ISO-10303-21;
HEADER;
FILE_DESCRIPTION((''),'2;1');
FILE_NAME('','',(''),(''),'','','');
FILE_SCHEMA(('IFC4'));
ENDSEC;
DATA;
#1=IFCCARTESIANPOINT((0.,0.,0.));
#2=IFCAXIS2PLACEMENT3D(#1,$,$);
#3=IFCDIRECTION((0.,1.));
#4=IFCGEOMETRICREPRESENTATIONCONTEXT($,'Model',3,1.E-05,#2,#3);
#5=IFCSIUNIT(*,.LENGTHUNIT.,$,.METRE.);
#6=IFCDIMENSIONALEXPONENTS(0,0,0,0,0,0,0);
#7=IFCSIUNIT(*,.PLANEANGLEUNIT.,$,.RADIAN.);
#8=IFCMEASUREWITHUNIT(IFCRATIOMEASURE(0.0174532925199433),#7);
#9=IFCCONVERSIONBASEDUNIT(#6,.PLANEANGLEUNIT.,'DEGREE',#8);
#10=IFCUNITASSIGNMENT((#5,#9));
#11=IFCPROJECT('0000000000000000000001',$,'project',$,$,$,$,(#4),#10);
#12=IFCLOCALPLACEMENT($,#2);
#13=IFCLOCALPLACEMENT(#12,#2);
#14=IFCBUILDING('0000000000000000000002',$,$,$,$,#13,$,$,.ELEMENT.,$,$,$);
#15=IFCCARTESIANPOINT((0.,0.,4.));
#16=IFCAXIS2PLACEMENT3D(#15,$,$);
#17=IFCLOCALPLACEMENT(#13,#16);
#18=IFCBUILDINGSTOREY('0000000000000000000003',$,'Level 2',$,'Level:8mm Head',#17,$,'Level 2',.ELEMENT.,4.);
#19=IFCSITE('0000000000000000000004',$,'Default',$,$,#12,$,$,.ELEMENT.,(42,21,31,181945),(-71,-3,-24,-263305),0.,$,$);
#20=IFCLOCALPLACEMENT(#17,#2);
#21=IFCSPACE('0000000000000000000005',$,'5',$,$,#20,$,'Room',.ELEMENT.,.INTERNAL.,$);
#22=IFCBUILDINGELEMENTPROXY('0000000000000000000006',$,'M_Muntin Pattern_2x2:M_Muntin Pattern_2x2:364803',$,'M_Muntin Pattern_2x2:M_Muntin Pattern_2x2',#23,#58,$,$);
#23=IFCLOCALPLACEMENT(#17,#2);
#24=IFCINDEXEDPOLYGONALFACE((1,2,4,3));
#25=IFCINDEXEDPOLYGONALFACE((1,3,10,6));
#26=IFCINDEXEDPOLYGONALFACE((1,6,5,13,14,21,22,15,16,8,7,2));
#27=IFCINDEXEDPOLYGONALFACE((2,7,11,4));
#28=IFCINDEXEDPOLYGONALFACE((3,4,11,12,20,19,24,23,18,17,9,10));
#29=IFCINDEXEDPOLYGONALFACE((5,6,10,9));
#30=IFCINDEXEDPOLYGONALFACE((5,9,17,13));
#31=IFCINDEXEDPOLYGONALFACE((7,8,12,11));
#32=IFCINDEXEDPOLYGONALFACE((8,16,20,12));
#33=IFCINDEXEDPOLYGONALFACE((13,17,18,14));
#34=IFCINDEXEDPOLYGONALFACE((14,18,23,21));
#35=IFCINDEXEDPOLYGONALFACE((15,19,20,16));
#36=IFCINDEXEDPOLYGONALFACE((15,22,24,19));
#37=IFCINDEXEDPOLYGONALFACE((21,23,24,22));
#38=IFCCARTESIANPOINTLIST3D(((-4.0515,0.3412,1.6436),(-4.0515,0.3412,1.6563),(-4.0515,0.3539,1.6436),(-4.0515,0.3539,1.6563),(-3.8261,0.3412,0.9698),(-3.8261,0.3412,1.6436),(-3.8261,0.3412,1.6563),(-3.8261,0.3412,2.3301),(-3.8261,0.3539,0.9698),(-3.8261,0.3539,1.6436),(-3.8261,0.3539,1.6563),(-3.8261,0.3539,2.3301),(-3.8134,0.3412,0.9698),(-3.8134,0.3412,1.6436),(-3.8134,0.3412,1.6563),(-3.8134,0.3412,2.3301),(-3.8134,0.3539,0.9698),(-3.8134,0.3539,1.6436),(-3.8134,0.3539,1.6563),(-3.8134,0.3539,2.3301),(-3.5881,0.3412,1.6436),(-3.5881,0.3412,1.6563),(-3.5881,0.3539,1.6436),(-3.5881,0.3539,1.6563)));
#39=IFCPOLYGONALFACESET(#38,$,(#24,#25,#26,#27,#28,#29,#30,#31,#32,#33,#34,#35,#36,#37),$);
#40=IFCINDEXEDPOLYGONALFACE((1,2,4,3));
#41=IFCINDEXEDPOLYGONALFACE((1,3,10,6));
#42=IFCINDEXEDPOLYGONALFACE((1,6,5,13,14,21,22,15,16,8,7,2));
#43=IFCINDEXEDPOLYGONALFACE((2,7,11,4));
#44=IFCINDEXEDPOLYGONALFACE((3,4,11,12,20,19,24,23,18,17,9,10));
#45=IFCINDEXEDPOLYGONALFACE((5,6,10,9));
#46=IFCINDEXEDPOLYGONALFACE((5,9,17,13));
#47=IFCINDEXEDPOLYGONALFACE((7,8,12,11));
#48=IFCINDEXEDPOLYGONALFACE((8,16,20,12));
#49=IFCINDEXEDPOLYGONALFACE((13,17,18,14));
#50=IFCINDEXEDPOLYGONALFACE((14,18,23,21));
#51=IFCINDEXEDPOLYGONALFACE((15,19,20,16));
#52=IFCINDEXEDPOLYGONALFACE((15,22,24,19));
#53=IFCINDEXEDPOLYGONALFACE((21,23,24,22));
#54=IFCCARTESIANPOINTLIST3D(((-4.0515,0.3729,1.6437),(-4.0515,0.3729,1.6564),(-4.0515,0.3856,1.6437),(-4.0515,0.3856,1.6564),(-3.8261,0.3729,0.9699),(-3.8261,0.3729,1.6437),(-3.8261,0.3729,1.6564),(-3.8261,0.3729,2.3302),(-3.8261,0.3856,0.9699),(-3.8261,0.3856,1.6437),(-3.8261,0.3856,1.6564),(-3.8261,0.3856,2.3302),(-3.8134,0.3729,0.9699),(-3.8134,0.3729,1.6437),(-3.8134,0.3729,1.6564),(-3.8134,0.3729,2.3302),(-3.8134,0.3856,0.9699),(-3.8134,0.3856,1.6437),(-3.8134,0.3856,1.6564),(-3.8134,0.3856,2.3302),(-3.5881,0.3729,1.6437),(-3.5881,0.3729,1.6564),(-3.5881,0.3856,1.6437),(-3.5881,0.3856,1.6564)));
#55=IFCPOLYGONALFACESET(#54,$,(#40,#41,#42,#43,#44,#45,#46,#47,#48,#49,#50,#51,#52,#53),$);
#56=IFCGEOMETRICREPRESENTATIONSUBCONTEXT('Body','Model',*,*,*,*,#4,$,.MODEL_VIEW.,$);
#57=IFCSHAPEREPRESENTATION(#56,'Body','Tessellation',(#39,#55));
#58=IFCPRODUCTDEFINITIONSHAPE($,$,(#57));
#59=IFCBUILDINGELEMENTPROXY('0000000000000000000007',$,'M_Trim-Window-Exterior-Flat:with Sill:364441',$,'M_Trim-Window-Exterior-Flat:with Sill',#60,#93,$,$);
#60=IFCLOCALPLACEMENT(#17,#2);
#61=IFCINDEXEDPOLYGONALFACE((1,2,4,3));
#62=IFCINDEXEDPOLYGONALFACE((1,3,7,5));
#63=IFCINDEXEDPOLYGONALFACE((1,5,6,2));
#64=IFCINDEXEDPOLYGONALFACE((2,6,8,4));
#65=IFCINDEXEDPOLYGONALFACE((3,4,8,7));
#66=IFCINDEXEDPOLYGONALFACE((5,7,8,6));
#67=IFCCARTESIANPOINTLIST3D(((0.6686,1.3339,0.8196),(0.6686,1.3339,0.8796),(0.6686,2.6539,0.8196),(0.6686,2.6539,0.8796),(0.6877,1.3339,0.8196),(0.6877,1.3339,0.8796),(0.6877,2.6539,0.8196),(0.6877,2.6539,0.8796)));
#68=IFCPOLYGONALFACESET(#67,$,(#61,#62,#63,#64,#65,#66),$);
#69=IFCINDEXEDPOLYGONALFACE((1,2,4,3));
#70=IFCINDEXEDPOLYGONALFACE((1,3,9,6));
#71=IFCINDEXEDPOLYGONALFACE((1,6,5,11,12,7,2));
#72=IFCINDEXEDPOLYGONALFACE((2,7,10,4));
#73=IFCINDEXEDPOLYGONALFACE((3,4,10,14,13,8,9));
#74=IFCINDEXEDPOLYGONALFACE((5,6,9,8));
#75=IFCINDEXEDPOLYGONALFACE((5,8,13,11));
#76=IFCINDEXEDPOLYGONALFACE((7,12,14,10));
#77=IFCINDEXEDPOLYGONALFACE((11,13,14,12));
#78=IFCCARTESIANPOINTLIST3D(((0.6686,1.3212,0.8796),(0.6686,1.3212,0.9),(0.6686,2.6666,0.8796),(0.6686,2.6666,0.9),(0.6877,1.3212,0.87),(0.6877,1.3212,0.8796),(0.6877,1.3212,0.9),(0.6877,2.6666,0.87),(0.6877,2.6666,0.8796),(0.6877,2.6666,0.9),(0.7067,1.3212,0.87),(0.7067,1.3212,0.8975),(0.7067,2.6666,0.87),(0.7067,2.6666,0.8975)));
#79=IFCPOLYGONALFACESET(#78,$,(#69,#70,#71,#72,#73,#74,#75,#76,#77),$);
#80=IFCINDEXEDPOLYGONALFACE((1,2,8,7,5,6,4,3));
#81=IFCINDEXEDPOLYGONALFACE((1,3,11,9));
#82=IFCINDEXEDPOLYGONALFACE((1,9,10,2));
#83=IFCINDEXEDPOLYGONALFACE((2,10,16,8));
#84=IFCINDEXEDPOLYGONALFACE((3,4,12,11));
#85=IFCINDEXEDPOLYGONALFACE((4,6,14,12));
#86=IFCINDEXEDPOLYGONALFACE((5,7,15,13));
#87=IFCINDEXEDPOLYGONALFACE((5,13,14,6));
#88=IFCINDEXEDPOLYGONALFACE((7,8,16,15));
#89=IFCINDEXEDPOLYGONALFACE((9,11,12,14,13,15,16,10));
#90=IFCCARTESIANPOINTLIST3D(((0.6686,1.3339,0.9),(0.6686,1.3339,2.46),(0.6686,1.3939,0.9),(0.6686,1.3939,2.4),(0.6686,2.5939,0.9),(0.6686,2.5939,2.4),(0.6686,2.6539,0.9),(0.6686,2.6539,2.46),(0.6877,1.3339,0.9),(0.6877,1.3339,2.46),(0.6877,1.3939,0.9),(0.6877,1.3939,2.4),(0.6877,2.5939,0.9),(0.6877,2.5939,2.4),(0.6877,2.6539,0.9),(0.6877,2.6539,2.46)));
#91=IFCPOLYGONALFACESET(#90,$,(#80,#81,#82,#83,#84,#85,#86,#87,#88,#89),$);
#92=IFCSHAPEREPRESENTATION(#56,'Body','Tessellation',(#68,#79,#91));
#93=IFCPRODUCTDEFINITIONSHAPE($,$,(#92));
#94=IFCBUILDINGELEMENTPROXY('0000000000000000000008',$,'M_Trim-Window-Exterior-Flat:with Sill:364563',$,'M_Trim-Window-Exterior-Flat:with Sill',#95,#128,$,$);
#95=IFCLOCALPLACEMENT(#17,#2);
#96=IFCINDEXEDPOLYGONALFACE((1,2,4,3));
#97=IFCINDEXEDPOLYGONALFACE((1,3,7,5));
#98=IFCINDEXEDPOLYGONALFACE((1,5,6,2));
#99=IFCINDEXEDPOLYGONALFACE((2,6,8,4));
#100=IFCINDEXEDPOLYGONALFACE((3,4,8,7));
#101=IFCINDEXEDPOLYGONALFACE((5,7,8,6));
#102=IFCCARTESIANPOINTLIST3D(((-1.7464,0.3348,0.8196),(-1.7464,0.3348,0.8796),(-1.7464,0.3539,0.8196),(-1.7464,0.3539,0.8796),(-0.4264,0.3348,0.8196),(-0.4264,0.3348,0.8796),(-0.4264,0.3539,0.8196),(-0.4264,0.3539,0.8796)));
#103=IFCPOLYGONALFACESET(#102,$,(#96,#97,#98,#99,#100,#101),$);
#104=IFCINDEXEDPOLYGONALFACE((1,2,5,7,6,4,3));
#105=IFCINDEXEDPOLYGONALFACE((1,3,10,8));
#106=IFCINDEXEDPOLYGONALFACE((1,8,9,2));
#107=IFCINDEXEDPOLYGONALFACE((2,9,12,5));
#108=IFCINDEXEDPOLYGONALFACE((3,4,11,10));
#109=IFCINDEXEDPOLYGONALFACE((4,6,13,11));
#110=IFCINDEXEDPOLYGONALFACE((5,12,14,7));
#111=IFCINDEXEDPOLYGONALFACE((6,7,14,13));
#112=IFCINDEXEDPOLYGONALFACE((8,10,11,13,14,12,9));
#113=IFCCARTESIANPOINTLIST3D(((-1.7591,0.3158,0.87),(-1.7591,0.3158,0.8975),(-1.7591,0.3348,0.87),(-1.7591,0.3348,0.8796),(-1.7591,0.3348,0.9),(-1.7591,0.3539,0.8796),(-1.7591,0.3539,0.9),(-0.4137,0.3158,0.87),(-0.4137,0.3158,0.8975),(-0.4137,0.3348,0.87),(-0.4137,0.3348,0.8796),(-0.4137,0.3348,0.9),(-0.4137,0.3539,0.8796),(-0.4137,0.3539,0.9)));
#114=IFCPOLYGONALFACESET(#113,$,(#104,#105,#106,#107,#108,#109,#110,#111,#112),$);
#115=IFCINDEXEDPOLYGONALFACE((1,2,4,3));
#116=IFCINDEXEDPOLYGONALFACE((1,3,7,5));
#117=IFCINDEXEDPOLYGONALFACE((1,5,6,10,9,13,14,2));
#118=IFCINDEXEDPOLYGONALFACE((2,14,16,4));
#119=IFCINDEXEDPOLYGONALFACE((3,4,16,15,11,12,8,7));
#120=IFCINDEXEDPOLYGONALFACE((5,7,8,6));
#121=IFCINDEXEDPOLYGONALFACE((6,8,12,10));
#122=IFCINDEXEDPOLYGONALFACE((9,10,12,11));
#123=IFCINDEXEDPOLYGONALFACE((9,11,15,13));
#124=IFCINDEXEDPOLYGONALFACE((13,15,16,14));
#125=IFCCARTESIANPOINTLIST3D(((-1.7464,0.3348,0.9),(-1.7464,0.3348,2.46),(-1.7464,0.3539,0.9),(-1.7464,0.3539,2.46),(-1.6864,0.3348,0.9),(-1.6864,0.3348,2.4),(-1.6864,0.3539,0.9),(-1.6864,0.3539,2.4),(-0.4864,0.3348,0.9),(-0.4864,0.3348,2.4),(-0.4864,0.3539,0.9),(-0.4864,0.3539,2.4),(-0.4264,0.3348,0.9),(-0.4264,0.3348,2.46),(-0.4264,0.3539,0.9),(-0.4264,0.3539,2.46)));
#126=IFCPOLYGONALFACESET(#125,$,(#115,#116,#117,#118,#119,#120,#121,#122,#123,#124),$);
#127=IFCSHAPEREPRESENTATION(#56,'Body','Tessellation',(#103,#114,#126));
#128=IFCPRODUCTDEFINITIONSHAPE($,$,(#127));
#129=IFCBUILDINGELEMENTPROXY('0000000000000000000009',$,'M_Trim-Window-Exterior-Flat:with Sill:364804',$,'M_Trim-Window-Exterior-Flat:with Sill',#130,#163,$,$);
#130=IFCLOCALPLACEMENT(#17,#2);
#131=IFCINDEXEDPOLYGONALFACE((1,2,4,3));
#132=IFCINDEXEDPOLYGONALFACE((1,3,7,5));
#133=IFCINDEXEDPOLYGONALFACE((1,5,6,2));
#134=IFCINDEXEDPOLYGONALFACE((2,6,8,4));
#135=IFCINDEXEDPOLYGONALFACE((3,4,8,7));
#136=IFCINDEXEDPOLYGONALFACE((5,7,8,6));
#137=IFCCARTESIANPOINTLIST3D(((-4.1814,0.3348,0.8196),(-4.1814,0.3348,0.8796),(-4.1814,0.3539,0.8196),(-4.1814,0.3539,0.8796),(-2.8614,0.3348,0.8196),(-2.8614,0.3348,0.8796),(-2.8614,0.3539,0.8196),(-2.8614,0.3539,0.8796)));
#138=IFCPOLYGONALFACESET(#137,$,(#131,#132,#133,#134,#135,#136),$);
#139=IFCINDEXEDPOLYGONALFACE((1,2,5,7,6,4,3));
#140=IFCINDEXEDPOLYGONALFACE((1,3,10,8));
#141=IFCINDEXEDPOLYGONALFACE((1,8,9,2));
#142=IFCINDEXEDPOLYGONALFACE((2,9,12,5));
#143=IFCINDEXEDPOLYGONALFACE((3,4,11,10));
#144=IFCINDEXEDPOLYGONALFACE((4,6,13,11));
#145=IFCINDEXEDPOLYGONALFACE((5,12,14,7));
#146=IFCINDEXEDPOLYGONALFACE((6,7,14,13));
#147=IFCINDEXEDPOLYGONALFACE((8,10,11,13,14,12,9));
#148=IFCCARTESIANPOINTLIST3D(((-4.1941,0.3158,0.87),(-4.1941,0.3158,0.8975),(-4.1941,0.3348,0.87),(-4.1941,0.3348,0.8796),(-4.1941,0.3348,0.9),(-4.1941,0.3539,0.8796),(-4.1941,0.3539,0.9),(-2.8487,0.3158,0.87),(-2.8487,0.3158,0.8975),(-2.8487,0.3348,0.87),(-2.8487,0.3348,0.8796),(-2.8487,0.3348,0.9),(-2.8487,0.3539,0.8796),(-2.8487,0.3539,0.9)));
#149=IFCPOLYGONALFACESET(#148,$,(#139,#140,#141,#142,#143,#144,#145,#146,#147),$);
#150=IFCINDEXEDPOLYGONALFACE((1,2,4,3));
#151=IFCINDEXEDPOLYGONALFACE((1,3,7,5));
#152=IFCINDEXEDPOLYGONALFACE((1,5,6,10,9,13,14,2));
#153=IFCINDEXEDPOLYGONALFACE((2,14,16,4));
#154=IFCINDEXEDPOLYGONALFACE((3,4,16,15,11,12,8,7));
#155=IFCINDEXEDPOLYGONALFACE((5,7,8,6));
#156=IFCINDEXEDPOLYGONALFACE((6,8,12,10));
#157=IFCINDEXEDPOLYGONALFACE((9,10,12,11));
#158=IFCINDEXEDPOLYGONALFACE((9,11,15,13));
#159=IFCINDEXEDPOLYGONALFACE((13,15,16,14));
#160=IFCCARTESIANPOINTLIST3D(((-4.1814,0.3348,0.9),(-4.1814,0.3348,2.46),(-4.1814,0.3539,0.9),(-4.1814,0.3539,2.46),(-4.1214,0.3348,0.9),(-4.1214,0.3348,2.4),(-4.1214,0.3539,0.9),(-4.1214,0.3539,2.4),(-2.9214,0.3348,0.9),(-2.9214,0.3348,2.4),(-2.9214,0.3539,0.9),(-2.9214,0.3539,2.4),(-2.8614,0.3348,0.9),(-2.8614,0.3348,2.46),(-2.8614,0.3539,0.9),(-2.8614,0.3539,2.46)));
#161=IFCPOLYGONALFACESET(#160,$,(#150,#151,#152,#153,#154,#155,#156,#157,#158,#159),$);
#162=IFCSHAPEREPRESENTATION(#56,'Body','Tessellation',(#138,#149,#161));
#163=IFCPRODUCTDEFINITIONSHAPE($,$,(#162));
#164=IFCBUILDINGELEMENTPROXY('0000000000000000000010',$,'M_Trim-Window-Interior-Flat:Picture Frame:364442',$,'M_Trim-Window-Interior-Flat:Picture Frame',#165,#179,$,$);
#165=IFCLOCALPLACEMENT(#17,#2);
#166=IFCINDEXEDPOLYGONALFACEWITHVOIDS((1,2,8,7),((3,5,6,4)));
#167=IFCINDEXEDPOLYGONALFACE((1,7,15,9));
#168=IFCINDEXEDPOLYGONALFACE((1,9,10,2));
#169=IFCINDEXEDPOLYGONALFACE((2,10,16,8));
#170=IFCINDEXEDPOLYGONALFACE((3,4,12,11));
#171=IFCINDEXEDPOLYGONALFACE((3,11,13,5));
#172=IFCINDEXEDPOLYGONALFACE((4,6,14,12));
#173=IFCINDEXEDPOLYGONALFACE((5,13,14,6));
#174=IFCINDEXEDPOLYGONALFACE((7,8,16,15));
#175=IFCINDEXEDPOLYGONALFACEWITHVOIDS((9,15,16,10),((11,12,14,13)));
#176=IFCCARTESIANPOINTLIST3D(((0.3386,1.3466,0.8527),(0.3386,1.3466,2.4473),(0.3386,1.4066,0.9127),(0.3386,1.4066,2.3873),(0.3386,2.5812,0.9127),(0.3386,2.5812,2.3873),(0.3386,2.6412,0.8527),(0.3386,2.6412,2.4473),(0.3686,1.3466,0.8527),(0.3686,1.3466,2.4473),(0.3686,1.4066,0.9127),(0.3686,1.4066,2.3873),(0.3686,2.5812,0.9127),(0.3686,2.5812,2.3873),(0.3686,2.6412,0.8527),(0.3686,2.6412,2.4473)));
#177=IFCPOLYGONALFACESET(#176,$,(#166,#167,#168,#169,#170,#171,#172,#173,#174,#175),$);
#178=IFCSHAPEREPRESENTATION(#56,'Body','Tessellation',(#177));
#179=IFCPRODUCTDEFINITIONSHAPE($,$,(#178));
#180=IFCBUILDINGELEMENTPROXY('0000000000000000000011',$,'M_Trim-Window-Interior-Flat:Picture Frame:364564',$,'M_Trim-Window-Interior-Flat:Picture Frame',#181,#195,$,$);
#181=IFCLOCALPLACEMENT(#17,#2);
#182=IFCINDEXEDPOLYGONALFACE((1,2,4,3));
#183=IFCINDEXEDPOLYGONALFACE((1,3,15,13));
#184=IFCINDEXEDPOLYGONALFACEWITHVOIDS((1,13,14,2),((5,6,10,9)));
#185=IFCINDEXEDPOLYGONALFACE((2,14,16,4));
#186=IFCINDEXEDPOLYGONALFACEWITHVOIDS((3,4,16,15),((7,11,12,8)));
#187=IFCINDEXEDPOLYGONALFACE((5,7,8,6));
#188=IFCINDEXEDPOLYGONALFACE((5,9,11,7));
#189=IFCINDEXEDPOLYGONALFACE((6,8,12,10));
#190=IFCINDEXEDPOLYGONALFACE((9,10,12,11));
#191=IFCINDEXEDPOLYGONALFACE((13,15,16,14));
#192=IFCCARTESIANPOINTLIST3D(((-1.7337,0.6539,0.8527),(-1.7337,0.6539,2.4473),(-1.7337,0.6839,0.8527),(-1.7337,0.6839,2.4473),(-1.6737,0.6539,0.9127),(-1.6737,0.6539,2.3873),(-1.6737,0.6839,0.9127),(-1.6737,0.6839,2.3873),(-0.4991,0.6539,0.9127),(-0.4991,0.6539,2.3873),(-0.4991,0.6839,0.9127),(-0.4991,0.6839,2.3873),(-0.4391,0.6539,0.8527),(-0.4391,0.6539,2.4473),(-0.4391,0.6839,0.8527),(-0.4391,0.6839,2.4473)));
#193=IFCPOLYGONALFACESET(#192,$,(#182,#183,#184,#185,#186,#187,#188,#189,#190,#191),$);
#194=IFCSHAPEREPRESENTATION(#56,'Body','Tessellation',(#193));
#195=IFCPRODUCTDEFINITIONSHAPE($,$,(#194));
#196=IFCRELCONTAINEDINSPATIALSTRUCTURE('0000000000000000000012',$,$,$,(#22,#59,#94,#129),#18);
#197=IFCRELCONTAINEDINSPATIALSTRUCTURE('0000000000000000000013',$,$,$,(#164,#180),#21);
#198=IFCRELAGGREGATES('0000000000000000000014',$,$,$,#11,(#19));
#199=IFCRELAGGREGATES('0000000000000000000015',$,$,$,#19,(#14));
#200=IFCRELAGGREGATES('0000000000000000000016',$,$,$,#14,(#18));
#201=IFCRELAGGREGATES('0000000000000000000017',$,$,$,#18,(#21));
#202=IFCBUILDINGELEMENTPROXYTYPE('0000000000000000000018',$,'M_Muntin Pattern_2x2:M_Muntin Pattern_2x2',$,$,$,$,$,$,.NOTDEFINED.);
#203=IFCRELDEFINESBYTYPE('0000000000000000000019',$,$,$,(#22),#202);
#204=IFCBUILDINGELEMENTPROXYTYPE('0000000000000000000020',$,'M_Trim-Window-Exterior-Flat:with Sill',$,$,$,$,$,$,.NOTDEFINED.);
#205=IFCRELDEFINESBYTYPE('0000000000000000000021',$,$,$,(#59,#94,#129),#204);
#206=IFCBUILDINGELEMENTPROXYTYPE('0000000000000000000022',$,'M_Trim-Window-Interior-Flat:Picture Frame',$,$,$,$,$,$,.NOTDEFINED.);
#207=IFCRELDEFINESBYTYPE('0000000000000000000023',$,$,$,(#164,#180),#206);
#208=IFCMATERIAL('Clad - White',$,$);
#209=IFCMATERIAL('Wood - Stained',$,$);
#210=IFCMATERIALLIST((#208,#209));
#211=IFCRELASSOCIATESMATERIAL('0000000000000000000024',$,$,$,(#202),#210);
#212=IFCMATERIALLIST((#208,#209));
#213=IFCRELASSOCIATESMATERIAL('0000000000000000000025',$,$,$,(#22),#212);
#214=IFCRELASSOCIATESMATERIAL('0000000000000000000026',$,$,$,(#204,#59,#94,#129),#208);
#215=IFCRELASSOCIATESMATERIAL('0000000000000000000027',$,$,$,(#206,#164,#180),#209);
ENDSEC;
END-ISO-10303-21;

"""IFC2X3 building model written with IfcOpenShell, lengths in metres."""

from ifc_helpers import new_model, entity, si_unit, converted_unit, direction, frame, frame_2d, origin, place, context, subcontext, project, spatial, polyline, rectangle, outline, extrude, source, transform, mapped, material, material_list, type_object, type_shapes, element, save


model = new_model("IFC2X3")

# Units and contexts
model_context = context("Model", 3, precision=1e-05, world=origin(), true_north=direction((0.0, 1.0)))
body_context = subcontext(model_context, "Body", "Model", "MODEL_VIEW")
ifc_project = project(units=[si_unit("LENGTHUNIT", "METRE"), converted_unit("PLANEANGLEUNIT", "DEGREE", entity("IfcRatioMeasure", 0.0174532925199433), si_unit("PLANEANGLEUNIT", "RADIAN"), dimensions=[0, 0, 0, 0, 0, 0, 0])], contexts=[model_context])

# Site, building, storey
site_placement = place(None, origin())
site = spatial("IfcSite", under=ifc_project, at=site_placement, Name="Default", CompositionType="ELEMENT", RefLatitude=(42, 21, 31, 181945), RefLongitude=(-71, -3, -24, -263305), RefElevation=0.0)
building_placement = place(site_placement, origin())
building = spatial("IfcBuilding", under=site, at=building_placement, CompositionType="ELEMENT")
storey_placement = place(building_placement, frame((0.0, 0.0, 4.0)))
storey = spatial("IfcBuildingStorey", under=building, at=storey_placement, Name="Level 2", ObjectType="Level:8mm Head", LongName="Level 2", CompositionType="ELEMENT", Elevation=4.0)

# Building element proxies
ifc_material_1 = material(Name="Clad - White")
ifc_material_2 = material(Name="Wood - Stained")
ifc_material_list_1 = material_list([ifc_material_1, ifc_material_2])
building_element_proxy_type_1 = type_object("IfcBuildingElementProxyType", Name="M_Muntin Pattern_2x2:M_Muntin Pattern_2x2", PredefinedType="NOTDEFINED", material=ifc_material_list_1)
shared_shape_1 = source(origin(), body_context, "Body", "SweptSolid", [
    extrude(outline(polyline([(0.0064, -0.0064), (0.6801, -0.0064), (0.6801, 0.0063), (0.0064, 0.0063), (0.0064, 0.2317), (-0.0063, 0.2317), (-0.0063, 0.0063), (-0.6802, 0.0063), (-0.6802, -0.0064), (-0.0063, -0.0064), (-0.0063, -0.2317), (0.0064, -0.2317), (0.0064, -0.0064)])), frame((0.0, -0.0222, 0.6801), z_axis=(0.0, 1.0, 0.0), x_axis=(0.0, 0.0, 1.0)), (0.0, 0.0, 1.0), 0.0127),
    extrude(outline(polyline([(0.0064, -0.0064), (0.6802, -0.0064), (0.6802, 0.0063), (0.0064, 0.0063), (0.0064, 0.2317), (-0.0063, 0.2317), (-0.0063, 0.0063), (-0.6802, 0.0063), (-0.6802, -0.0064), (-0.0063, -0.0064), (-0.0063, -0.2317), (0.0064, -0.2317), (0.0064, -0.0064)])), frame((0.0, 0.0095, 0.6802), z_axis=(0.0, 1.0, 0.0), x_axis=(0.0, 0.0, 1.0)), (0.0, 0.0, 1.0), 0.0127),
])
type_shapes(building_element_proxy_type_1, [shared_shape_1])
ifc_material_list_2 = material_list([ifc_material_1, ifc_material_2])
proxy_1_placement = place(storey_placement, frame((-3.8198, 0.3634, 0.9699)))
element("IfcBuildingElementProxy", 1, at=proxy_1_placement, inside=storey, type_object=building_element_proxy_type_1, material=ifc_material_list_2, Name="M_Muntin Pattern_2x2:M_Muntin Pattern_2x2:364803", ObjectType="M_Muntin Pattern_2x2:M_Muntin Pattern_2x2", context=body_context, shape_type="MappedRepresentation", body=[
    mapped(shared_shape_1, transform((0.0, 0.0, 0.0), scale=1.0)),
])
building_element_proxy_type_2 = type_object("IfcBuildingElementProxyType", Name="M_Trim-Window-Exterior-Flat:with Sill", PredefinedType="NOTDEFINED", material=ifc_material_1)
shared_shape_2 = source(origin(), body_context, "Body", "SweptSolid", [
    extrude(rectangle(XDim=1.32, YDim=0.06, at=frame_2d((0.0, 0.0), x_axis=(1.0, 0.0))), frame((0.0, -1.5504, 0.0), z_axis=(0.0, 0.0, 1.0), x_axis=(-1.0, 0.0, 0.0)), (0.0, 0.0, 1.0), 0.0191),
    extrude(outline(polyline([(-0.019, -0.0152), (0.0, -0.0152), (0.0, -0.0057), (0.019, -0.0057), (0.019, 0.0148), (0.0, 0.0148), (-0.019, 0.0123), (-0.019, -0.0152)])), frame((-0.6727, -1.5148, 0.019), z_axis=(1.0, 0.0, 0.0), x_axis=(0.0, 0.0, -1.0)), (0.0, 0.0, 1.0), 1.3454),
    extrude(outline(polyline([(-0.795, -0.66), (0.765, -0.66), (0.765, -0.6), (-0.735, -0.6), (-0.735, 0.6), (0.765, 0.6), (0.765, 0.66), (-0.795, 0.66), (-0.795, -0.66)])), frame((0.0, -0.735, 0.0), z_axis=(0.0, 0.0, 1.0), x_axis=(0.0, -1.0, 0.0)), (0.0, 0.0, 1.0), 0.0191),
])
type_shapes(building_element_proxy_type_2, [shared_shape_2])
for number, where, z_axis, x_axis, name in (
    (2, (0.6686, 1.9939, 2.4), (1.0, 0.0, 0.0), (0.0, 1.0, 0.0), "M_Trim-Window-Exterior-Flat:with Sill:364441"),
    (3, (-1.0864, 0.3539, 2.4), (0.0, -1.0, 0.0), (1.0, 0.0, 0.0), "M_Trim-Window-Exterior-Flat:with Sill:364563"),
    (4, (-3.5214, 0.3539, 2.4), (0.0, -1.0, 0.0), (1.0, 0.0, 0.0), "M_Trim-Window-Exterior-Flat:with Sill:364804"),
):
    element("IfcBuildingElementProxy", number, at=place(storey_placement, frame(where, z_axis=z_axis, x_axis=x_axis)), inside=storey, type_object=building_element_proxy_type_2, material=ifc_material_1, Name=name, ObjectType="M_Trim-Window-Exterior-Flat:with Sill", context=body_context, shape_type="MappedRepresentation", body=[
        mapped(shared_shape_2, transform((0.0, 0.0, 0.0), scale=1.0)),
    ])

# Shared definitions
space_1_placement = place(storey_placement, origin())
space_1 = spatial("IfcSpace", under=storey, at=space_1_placement, Name="5", LongName="Room", CompositionType="ELEMENT", InteriorOrExteriorSpace="INTERNAL")

# Building element proxies
building_element_proxy_type_3 = type_object("IfcBuildingElementProxyType", Name="M_Trim-Window-Interior-Flat:Picture Frame", PredefinedType="NOTDEFINED", material=ifc_material_2)
shared_shape_3 = source(origin(), body_context, "Body", "SweptSolid", [
    extrude(outline(polyline([(-0.6473, -0.7973), (0.6473, -0.7973), (0.6473, 0.7973), (-0.6473, 0.7973), (-0.6473, -0.7973)]), holes=[polyline([(-0.5873, -0.7373), (-0.5873, 0.7373), (0.5873, 0.7373), (0.5873, -0.7373), (-0.5873, -0.7373)])]), frame((0.0, -0.75, 0.0), z_axis=(0.0, 0.0, 1.0), x_axis=(-1.0, 0.0, 0.0)), (0.0, 0.0, 1.0), 0.03),
])
type_shapes(building_element_proxy_type_3, [shared_shape_3])
for number, where, z_axis, x_axis, name in (
    (5, (0.3686, 1.9939, 2.4), (-1.0, 0.0, 0.0), (0.0, -1.0, 0.0), "M_Trim-Window-Interior-Flat:Picture Frame:364442"),
    (6, (-1.0864, 0.6539, 2.4), (0.0, 1.0, 0.0), (-1.0, 0.0, 0.0), "M_Trim-Window-Interior-Flat:Picture Frame:364564"),
):
    element("IfcBuildingElementProxy", number, at=place(space_1_placement, frame(where, z_axis=z_axis, x_axis=x_axis)), inside=space_1, type_object=building_element_proxy_type_3, material=ifc_material_2, Name=name, ObjectType="M_Trim-Window-Interior-Flat:Picture Frame", context=body_context, shape_type="MappedRepresentation", body=[
        mapped(shared_shape_3, transform((0.0, 0.0, 0.0), scale=1.0)),
    ])

save(model, "model.ifc")
